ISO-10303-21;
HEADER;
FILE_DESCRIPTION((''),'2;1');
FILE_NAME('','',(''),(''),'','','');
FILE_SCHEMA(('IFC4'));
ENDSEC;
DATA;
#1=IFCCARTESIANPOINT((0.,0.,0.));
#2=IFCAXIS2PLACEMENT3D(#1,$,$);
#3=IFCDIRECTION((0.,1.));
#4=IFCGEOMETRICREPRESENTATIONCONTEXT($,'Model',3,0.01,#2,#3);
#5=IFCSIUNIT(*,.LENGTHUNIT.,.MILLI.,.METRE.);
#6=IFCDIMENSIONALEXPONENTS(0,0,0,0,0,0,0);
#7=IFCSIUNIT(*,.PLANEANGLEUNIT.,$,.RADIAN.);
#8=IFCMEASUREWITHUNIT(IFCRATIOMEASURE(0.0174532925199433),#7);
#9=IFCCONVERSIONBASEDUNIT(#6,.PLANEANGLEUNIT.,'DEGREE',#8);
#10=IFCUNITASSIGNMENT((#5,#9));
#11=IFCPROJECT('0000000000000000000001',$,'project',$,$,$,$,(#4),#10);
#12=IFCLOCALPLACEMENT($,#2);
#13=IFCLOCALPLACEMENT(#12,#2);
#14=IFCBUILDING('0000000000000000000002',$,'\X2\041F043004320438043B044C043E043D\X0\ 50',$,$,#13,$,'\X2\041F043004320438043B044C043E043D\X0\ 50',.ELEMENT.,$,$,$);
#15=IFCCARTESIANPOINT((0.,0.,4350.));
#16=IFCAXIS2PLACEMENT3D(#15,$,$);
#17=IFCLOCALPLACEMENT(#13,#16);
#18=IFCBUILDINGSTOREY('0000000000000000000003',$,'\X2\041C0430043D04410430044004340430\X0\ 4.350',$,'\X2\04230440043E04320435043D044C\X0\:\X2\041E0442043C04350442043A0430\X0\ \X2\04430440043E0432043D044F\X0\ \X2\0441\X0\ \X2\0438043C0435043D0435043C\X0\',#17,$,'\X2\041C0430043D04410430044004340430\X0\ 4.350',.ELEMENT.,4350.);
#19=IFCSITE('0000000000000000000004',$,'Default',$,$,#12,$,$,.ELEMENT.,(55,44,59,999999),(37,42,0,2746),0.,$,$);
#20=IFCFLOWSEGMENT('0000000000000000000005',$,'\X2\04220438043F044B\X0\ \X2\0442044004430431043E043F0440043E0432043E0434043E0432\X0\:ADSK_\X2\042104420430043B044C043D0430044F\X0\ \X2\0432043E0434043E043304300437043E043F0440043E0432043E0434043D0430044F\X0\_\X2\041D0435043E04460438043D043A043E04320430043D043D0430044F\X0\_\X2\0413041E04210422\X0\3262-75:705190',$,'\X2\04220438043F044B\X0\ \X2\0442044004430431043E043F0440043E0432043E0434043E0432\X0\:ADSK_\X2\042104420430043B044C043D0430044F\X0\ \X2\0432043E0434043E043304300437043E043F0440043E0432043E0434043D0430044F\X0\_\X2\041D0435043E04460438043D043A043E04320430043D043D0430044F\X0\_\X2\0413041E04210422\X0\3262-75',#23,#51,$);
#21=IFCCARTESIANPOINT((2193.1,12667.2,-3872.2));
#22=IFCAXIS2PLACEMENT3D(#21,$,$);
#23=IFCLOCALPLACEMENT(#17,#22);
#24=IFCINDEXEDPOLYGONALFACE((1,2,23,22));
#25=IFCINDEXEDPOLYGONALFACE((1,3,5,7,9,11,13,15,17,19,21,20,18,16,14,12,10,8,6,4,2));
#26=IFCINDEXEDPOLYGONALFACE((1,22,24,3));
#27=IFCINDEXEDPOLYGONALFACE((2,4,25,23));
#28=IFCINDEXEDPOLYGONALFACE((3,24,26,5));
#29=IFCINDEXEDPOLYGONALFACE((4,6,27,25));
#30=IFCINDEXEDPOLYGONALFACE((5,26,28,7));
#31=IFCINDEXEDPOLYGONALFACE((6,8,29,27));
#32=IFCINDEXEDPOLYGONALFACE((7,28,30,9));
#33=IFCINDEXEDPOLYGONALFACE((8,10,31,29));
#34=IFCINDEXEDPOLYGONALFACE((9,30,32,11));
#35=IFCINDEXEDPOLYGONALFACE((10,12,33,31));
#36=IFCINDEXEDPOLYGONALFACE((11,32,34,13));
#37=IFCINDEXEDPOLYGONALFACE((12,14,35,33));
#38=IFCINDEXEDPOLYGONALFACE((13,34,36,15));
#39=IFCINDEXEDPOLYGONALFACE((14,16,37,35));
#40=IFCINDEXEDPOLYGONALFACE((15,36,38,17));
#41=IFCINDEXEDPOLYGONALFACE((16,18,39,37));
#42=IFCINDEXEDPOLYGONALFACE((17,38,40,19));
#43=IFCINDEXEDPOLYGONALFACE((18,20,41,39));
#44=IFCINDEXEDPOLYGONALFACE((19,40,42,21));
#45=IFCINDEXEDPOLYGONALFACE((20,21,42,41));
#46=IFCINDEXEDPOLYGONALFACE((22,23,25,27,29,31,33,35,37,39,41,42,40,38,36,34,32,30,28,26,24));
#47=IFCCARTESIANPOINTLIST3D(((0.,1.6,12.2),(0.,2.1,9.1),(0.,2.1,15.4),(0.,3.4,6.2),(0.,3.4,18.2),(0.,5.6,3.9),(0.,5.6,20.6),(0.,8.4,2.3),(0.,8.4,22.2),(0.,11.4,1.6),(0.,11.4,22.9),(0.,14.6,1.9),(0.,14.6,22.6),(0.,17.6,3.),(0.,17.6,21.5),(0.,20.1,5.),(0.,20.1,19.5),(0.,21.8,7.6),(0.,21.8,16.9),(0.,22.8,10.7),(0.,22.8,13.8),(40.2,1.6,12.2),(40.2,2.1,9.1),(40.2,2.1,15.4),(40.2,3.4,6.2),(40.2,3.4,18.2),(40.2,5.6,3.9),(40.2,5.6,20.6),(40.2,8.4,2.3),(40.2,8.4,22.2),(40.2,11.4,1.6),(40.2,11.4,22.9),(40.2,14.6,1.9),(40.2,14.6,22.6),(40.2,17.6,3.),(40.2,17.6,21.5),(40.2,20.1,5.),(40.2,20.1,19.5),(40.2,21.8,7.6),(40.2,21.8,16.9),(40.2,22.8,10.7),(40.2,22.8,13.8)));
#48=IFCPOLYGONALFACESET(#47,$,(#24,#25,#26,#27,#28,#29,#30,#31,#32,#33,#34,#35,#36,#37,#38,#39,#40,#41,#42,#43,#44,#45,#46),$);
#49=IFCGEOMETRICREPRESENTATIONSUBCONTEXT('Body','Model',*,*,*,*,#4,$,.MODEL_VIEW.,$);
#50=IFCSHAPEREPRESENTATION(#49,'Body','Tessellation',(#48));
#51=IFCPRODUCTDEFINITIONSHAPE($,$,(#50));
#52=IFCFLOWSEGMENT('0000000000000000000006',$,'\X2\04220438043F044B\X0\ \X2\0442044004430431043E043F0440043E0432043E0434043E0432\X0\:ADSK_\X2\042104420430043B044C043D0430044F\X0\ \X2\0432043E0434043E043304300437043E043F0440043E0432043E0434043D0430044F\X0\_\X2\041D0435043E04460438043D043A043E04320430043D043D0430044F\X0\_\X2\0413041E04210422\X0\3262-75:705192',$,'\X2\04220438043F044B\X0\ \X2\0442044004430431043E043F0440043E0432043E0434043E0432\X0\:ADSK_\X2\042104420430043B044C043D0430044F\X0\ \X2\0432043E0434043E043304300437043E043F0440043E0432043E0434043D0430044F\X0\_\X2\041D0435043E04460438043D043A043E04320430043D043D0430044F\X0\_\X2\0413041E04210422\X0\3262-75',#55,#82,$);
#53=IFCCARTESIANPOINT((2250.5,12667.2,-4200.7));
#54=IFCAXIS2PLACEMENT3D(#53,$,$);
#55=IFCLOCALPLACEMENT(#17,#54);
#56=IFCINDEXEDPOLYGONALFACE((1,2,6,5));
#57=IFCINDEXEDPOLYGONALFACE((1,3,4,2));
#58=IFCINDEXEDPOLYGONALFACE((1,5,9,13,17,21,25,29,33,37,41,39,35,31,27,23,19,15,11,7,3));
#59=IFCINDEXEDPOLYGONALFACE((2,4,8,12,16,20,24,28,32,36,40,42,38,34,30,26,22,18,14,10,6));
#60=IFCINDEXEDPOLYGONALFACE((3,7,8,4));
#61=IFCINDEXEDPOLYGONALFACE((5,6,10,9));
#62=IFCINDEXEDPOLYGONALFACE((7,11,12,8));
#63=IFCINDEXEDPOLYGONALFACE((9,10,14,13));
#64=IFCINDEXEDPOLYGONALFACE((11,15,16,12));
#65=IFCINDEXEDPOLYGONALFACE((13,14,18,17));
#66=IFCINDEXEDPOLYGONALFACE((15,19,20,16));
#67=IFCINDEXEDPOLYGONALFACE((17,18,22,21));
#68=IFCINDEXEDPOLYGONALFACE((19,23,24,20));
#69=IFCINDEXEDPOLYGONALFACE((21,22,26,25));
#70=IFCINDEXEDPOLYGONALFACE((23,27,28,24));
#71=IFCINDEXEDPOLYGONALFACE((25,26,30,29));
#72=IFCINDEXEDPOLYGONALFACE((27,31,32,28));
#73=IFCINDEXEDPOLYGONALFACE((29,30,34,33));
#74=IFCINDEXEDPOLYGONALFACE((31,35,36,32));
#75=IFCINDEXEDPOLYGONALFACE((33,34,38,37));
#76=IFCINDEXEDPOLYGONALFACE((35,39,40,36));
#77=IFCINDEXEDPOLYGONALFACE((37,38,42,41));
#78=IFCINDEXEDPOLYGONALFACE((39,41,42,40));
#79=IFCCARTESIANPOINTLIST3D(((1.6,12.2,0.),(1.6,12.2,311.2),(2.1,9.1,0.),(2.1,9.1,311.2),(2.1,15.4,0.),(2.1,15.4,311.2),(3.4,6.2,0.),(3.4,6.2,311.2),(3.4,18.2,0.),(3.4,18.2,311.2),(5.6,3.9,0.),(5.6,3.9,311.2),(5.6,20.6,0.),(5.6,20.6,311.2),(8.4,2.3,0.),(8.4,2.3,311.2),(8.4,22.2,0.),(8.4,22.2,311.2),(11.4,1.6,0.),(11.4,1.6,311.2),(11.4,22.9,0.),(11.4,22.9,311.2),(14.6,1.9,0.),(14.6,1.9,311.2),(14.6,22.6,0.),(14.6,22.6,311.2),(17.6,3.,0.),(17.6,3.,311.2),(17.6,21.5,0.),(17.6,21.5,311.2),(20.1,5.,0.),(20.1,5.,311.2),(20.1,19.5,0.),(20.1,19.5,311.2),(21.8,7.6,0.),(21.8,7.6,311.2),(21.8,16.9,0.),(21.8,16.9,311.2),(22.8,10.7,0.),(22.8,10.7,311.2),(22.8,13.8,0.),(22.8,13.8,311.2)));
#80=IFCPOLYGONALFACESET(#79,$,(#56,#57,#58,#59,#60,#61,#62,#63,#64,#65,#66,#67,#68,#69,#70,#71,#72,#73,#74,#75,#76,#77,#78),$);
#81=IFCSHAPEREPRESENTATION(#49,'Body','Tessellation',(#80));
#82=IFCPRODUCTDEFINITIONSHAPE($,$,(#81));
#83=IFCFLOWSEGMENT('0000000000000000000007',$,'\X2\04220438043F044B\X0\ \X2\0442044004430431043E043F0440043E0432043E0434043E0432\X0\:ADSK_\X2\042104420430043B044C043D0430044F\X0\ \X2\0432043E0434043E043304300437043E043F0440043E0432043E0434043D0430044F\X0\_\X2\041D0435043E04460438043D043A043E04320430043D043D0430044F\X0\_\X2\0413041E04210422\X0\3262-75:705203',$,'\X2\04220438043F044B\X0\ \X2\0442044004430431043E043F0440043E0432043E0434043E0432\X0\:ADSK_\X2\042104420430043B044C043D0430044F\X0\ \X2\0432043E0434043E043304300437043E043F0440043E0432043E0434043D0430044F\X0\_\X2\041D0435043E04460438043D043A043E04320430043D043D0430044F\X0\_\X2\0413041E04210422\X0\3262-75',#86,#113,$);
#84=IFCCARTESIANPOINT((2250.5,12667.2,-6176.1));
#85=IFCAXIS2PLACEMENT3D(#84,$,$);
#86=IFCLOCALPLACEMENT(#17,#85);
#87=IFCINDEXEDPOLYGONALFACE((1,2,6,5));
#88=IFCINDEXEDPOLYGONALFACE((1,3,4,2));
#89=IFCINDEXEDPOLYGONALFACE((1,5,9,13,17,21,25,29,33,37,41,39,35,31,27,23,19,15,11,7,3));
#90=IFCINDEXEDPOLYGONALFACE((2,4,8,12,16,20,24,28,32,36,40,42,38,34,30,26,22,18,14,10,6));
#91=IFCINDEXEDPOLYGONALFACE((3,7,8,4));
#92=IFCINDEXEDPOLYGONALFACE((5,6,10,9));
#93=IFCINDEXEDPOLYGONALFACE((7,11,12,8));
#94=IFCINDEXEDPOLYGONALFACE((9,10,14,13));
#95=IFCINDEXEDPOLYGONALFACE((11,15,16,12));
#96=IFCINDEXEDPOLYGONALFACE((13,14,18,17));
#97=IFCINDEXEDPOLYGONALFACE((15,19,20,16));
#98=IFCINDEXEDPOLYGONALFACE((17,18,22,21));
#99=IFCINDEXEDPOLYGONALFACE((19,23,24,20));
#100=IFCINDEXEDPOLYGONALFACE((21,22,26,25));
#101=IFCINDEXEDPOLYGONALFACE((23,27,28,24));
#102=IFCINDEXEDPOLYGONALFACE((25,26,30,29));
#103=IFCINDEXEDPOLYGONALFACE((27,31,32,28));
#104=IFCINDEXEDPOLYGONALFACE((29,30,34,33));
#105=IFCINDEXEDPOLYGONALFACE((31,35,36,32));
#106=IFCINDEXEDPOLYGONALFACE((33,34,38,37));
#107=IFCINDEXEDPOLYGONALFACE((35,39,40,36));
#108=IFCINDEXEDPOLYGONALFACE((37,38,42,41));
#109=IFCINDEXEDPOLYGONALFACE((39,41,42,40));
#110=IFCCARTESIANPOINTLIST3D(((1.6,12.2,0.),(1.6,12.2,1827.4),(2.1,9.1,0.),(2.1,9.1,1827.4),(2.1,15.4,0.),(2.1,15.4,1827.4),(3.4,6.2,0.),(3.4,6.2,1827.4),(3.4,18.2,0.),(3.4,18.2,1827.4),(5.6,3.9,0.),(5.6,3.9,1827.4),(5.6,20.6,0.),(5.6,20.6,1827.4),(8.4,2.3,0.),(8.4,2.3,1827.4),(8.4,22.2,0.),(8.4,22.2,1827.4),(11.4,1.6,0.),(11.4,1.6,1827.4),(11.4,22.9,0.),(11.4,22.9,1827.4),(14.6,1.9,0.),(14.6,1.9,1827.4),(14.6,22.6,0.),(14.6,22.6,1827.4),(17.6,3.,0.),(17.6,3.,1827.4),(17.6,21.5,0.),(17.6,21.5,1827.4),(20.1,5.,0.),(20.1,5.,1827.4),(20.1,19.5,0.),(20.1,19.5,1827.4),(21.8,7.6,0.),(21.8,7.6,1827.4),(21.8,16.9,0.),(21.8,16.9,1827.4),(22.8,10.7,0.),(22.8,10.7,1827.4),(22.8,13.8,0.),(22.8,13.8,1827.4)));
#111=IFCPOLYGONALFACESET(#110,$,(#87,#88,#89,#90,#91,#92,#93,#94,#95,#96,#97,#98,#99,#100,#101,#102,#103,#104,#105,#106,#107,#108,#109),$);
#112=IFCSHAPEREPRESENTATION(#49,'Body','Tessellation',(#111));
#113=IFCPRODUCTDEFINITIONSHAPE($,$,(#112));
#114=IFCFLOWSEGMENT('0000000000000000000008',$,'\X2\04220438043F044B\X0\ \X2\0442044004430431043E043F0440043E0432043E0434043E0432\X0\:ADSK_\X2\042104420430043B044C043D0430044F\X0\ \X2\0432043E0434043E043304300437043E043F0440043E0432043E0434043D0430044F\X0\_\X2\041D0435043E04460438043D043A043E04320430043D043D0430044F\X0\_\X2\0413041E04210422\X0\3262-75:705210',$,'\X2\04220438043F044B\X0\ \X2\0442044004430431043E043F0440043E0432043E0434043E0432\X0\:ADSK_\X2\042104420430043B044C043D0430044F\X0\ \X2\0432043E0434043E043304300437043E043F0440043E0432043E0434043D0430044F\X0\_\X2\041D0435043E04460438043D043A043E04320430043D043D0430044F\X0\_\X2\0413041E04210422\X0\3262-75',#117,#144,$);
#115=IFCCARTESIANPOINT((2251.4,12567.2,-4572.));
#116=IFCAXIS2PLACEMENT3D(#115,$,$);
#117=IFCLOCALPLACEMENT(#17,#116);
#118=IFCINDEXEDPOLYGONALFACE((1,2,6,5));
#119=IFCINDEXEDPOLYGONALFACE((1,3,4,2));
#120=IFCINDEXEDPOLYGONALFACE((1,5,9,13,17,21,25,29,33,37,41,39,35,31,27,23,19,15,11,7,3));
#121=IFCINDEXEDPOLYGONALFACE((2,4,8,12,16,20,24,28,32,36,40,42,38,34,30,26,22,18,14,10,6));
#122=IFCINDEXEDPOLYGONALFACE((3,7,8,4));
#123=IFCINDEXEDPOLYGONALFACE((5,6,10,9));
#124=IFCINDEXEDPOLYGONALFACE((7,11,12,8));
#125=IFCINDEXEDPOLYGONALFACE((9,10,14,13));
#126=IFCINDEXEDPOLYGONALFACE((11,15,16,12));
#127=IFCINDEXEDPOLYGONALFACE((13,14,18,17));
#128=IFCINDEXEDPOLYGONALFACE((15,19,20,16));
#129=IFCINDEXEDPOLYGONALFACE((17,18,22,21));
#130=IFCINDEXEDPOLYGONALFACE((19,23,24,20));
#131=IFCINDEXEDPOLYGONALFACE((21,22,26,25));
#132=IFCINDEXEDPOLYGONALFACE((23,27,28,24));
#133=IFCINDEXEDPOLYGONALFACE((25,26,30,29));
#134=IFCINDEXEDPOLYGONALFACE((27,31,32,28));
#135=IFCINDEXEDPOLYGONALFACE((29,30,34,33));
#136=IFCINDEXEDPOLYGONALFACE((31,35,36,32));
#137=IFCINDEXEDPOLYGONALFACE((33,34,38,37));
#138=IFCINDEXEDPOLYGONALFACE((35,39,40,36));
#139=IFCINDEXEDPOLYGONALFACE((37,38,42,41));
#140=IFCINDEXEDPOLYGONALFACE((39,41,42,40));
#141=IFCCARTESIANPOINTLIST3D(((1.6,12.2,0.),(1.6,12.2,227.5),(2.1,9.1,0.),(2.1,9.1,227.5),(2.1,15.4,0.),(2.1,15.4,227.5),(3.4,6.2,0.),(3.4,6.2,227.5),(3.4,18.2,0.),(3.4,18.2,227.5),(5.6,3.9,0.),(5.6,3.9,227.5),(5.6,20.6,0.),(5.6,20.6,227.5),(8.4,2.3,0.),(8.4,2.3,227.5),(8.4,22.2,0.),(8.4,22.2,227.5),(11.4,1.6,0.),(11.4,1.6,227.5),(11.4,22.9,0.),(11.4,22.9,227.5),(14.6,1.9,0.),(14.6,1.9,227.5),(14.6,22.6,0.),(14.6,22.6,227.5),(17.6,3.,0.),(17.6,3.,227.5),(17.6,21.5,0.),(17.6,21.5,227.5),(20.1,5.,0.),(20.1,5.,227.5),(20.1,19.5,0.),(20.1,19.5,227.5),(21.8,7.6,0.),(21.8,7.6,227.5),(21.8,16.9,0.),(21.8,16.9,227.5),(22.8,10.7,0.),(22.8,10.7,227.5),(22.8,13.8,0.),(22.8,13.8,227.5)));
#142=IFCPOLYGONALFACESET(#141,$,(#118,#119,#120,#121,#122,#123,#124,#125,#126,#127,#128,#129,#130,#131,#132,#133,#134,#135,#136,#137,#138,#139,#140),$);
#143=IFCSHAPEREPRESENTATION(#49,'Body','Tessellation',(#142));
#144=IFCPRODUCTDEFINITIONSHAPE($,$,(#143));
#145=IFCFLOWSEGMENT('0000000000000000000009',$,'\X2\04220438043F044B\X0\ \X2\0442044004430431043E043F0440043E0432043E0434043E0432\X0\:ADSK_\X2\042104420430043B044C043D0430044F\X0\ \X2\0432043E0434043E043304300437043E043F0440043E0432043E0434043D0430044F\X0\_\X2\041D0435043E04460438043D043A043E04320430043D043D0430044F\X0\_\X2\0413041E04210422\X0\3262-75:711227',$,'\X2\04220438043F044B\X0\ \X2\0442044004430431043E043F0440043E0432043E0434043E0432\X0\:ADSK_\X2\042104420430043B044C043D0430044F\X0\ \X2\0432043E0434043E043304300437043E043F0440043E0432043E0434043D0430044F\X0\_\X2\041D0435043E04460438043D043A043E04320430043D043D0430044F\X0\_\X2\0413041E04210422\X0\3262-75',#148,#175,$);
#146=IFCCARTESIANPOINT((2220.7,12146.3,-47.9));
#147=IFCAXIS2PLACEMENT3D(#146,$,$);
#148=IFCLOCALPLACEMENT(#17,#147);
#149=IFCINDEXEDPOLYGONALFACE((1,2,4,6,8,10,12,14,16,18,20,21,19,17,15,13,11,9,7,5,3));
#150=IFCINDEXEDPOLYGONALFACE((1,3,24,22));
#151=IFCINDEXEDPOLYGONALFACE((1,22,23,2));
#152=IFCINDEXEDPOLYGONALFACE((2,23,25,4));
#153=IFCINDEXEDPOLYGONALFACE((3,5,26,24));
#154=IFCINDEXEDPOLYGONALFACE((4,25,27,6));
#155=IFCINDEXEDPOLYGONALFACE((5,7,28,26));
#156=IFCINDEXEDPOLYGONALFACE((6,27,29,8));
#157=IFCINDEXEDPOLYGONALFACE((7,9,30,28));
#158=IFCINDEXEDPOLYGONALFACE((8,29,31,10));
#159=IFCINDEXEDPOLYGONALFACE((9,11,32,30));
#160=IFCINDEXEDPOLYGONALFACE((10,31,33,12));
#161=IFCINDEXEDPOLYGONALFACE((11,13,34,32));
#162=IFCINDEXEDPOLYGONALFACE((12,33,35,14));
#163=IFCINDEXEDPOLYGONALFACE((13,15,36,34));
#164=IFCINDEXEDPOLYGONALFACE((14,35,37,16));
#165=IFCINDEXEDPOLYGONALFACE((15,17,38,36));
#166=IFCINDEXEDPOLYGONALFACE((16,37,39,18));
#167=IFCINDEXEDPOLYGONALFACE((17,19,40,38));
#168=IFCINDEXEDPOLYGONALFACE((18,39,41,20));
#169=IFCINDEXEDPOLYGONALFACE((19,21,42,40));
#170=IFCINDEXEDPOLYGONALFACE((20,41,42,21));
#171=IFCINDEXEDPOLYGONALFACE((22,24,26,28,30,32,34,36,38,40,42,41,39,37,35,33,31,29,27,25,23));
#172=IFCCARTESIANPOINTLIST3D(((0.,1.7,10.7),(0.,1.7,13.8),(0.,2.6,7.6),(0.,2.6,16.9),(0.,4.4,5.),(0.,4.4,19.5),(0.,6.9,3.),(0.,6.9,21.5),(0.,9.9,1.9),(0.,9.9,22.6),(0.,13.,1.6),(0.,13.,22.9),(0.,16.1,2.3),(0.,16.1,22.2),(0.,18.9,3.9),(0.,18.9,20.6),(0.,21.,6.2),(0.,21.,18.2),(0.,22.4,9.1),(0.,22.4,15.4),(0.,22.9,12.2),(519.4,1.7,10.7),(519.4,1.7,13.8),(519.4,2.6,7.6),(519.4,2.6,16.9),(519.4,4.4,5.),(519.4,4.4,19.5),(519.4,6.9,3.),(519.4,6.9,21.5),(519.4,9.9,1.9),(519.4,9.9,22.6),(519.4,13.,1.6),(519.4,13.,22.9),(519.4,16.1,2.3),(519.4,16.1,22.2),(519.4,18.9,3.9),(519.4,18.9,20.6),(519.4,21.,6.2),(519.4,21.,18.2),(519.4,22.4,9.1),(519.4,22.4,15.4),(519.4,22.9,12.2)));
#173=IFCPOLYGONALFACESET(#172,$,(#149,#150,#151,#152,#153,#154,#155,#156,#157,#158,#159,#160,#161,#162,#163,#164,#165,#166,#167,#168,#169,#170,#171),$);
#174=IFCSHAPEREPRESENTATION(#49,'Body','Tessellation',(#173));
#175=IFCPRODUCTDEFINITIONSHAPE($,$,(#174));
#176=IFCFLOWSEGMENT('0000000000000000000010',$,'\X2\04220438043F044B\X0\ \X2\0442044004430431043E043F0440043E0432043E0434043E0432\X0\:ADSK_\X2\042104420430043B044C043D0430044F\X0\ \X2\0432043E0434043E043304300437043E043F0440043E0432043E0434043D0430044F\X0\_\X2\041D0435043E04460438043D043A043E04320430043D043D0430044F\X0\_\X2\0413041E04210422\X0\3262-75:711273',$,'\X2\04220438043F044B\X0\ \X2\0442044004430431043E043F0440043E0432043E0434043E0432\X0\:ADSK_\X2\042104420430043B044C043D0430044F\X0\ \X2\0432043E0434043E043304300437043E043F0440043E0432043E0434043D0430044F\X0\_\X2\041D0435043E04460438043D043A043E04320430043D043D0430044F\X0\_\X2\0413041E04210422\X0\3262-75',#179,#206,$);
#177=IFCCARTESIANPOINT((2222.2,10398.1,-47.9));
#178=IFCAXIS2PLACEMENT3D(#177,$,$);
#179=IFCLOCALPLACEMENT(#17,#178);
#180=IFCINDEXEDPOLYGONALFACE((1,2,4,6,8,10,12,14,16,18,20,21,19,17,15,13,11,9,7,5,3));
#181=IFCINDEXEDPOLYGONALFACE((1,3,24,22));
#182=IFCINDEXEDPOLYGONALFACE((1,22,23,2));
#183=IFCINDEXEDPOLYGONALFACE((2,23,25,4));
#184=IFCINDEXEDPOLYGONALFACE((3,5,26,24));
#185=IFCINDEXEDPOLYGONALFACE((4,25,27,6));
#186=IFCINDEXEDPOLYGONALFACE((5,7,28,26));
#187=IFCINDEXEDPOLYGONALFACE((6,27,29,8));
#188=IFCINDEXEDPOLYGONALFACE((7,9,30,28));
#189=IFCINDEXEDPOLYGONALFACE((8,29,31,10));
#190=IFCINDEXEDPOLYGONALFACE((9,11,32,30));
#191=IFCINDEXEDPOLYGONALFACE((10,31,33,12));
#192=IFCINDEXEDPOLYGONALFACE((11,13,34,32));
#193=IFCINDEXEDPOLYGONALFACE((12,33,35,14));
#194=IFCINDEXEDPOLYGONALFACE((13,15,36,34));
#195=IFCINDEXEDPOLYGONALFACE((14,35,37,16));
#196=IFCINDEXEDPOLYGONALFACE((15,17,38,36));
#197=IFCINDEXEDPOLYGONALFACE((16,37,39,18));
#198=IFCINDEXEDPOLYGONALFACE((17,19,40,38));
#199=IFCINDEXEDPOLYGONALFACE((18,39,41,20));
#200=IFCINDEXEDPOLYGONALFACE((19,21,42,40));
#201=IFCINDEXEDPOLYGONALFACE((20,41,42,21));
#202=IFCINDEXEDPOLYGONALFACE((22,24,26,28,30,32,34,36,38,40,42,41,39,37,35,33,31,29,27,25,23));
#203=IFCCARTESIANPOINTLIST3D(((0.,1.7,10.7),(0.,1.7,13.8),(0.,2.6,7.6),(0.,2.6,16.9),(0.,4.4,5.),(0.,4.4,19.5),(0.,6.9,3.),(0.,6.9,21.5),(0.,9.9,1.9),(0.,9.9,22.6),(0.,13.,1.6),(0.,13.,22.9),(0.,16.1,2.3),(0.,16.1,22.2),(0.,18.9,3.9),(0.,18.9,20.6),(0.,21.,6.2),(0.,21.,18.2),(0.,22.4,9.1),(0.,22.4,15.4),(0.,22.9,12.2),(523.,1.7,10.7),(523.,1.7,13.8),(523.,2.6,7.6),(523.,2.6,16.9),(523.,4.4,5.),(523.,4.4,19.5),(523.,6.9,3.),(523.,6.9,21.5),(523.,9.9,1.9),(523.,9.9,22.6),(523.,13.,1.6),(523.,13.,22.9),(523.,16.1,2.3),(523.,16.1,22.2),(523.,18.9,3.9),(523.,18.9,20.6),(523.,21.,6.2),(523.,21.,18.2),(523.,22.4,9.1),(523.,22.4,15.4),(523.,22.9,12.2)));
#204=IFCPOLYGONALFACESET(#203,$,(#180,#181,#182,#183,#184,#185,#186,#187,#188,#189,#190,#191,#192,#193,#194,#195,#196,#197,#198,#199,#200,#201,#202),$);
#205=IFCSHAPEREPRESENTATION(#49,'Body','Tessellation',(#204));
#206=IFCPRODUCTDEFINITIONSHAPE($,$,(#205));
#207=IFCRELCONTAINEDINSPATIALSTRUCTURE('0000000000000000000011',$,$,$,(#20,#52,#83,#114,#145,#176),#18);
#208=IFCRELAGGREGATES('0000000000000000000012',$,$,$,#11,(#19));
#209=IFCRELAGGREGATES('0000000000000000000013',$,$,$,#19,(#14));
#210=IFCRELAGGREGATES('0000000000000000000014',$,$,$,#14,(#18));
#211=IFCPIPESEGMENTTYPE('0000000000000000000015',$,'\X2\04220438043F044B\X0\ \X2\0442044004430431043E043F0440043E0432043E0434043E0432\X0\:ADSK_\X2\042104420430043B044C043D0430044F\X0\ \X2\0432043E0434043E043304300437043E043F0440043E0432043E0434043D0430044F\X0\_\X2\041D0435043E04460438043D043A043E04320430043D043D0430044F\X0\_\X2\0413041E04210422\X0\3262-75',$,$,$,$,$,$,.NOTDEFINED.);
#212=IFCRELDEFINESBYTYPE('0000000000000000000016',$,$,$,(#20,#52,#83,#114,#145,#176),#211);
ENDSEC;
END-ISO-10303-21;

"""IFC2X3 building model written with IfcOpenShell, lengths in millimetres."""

from ifc_helpers import new_model, entity, si_unit, converted_unit, direction, frame, frame_2d, origin, origin_2d_with_axis, place, context, subcontext, project, spatial, circle, extrude, type_object, element, save


model = new_model("IFC2X3")

# Units and contexts
model_context = context("Model", 3, precision=0.01, world=origin(), true_north=direction((0.0, 1.0)))
body_context = subcontext(model_context, "Body", "Model", "MODEL_VIEW")
ifc_project = project(units=[si_unit("LENGTHUNIT", "METRE", prefix="MILLI"), converted_unit("PLANEANGLEUNIT", "DEGREE", entity("IfcRatioMeasure", 0.0174532925199433), si_unit("PLANEANGLEUNIT", "RADIAN"), dimensions=[0, 0, 0, 0, 0, 0, 0])], contexts=[model_context])

# Site, building, storey
site_placement = place(None, origin())
site = spatial("IfcSite", under=ifc_project, at=site_placement, Name="Default", CompositionType="ELEMENT", RefLatitude=(55, 44, 59, 999999), RefLongitude=(37, 42, 0, 2746), RefElevation=0.0)
building_placement = place(site_placement, origin())
building = spatial("IfcBuilding", under=site, at=building_placement, Name="Павильон 50", LongName="Павильон 50", CompositionType="ELEMENT")
storey_placement = place(building_placement, frame((0.0, 0.0, 4350.0)))
storey = spatial("IfcBuildingStorey", under=building, at=storey_placement, Name="Мансарда 4.350", ObjectType="Уровень:Отметка уровня с именем", LongName="Мансарда 4.350", CompositionType="ELEMENT", Elevation=4350.0)

# Flow segments
pipe_segment_type = type_object("IfcPipeSegmentType", Name="Типы трубопроводов:ADSK_Стальная водогазопроводная_Неоцинкованная_ГОСТ3262-75", PredefinedType="NOTDEFINED")
flow_segment_1_placement = place(storey_placement, frame((2193.1, 12667.2, -3872.2)))
element("IfcFlowSegment", 1, at=flow_segment_1_placement, inside=storey, type_object=pipe_segment_type, Name="Типы трубопроводов:ADSK_Стальная водогазопроводная_Неоцинкованная_ГОСТ3262-75:705190", ObjectType="Типы трубопроводов:ADSK_Стальная водогазопроводная_Неоцинкованная_ГОСТ3262-75", context=body_context, shape_type="SweptSolid", body=[
    extrude(circle(Radius=10.7, at=origin_2d_with_axis()), frame((0.0, 12.2, 12.2), z_axis=(1.0, 0.0, 0.0), x_axis=(0.0, -1.0, 0.0)), (0.0, 0.0, 1.0), 40.2),
])
flow_segment_2_placement = place(storey_placement, frame((2250.5, 12667.2, -4200.7)))
element("IfcFlowSegment", 2, at=flow_segment_2_placement, inside=storey, type_object=pipe_segment_type, Name="Типы трубопроводов:ADSK_Стальная водогазопроводная_Неоцинкованная_ГОСТ3262-75:705192", ObjectType="Типы трубопроводов:ADSK_Стальная водогазопроводная_Неоцинкованная_ГОСТ3262-75", context=body_context, shape_type="SweptSolid", body=[
    extrude(circle(Radius=10.7, at=origin_2d_with_axis()), frame((12.2, 12.2, 0.0), z_axis=(0.0, 0.0, 1.0), x_axis=(-1.0, 0.0, 0.0)), (0.0, 0.0, 1.0), 311.2),
])
flow_segment_3_placement = place(storey_placement, frame((2250.5, 12667.2, -6176.1)))
element("IfcFlowSegment", 3, at=flow_segment_3_placement, inside=storey, type_object=pipe_segment_type, Name="Типы трубопроводов:ADSK_Стальная водогазопроводная_Неоцинкованная_ГОСТ3262-75:705203", ObjectType="Типы трубопроводов:ADSK_Стальная водогазопроводная_Неоцинкованная_ГОСТ3262-75", context=body_context, shape_type="SweptSolid", body=[
    extrude(circle(Radius=10.7, at=frame_2d((0.0, 0.0), x_axis=(1.0, 0.0))), frame((12.2, 12.2, 0.0), z_axis=(0.0, 0.0, 1.0), x_axis=(-1.0, 0.0, 0.0)), (0.0, 0.0, 1.0), 1827.4),
])
flow_segment_4_placement = place(storey_placement, frame((2251.4, 12567.2, -4572.0)))
element("IfcFlowSegment", 4, at=flow_segment_4_placement, inside=storey, type_object=pipe_segment_type, Name="Типы трубопроводов:ADSK_Стальная водогазопроводная_Неоцинкованная_ГОСТ3262-75:705210", ObjectType="Типы трубопроводов:ADSK_Стальная водогазопроводная_Неоцинкованная_ГОСТ3262-75", context=body_context, shape_type="SweptSolid", body=[
    extrude(circle(Radius=10.7, at=origin_2d_with_axis()), frame((12.2, 12.2, 0.0), z_axis=(0.0, 0.0, 1.0), x_axis=(-1.0, 0.0, 0.0)), (0.0, 0.0, 1.0), 227.5),
])
flow_segment_5_placement = place(storey_placement, frame((2220.7, 12146.3, -47.9)))
element("IfcFlowSegment", 5, at=flow_segment_5_placement, inside=storey, type_object=pipe_segment_type, Name="Типы трубопроводов:ADSK_Стальная водогазопроводная_Неоцинкованная_ГОСТ3262-75:711227", ObjectType="Типы трубопроводов:ADSK_Стальная водогазопроводная_Неоцинкованная_ГОСТ3262-75", context=body_context, shape_type="SweptSolid", body=[
    extrude(circle(Radius=10.7, at=origin_2d_with_axis()), frame((0.0, 12.2, 12.2), z_axis=(1.0, 0.0, 0.0), x_axis=(0.0, 1.0, 0.0)), (0.0, 0.0, 1.0), 519.4),
])
flow_segment_6_placement = place(storey_placement, frame((2222.2, 10398.1, -47.9)))
element("IfcFlowSegment", 6, at=flow_segment_6_placement, inside=storey, type_object=pipe_segment_type, Name="Типы трубопроводов:ADSK_Стальная водогазопроводная_Неоцинкованная_ГОСТ3262-75:711273", ObjectType="Типы трубопроводов:ADSK_Стальная водогазопроводная_Неоцинкованная_ГОСТ3262-75", context=body_context, shape_type="SweptSolid", body=[
    extrude(circle(Radius=10.7, at=origin_2d_with_axis()), frame((0.0, 12.2, 12.2), z_axis=(1.0, 0.0, 0.0), x_axis=(0.0, 1.0, 0.0)), (0.0, 0.0, 1.0), 523.0),
])

save(model, "model.ifc")
